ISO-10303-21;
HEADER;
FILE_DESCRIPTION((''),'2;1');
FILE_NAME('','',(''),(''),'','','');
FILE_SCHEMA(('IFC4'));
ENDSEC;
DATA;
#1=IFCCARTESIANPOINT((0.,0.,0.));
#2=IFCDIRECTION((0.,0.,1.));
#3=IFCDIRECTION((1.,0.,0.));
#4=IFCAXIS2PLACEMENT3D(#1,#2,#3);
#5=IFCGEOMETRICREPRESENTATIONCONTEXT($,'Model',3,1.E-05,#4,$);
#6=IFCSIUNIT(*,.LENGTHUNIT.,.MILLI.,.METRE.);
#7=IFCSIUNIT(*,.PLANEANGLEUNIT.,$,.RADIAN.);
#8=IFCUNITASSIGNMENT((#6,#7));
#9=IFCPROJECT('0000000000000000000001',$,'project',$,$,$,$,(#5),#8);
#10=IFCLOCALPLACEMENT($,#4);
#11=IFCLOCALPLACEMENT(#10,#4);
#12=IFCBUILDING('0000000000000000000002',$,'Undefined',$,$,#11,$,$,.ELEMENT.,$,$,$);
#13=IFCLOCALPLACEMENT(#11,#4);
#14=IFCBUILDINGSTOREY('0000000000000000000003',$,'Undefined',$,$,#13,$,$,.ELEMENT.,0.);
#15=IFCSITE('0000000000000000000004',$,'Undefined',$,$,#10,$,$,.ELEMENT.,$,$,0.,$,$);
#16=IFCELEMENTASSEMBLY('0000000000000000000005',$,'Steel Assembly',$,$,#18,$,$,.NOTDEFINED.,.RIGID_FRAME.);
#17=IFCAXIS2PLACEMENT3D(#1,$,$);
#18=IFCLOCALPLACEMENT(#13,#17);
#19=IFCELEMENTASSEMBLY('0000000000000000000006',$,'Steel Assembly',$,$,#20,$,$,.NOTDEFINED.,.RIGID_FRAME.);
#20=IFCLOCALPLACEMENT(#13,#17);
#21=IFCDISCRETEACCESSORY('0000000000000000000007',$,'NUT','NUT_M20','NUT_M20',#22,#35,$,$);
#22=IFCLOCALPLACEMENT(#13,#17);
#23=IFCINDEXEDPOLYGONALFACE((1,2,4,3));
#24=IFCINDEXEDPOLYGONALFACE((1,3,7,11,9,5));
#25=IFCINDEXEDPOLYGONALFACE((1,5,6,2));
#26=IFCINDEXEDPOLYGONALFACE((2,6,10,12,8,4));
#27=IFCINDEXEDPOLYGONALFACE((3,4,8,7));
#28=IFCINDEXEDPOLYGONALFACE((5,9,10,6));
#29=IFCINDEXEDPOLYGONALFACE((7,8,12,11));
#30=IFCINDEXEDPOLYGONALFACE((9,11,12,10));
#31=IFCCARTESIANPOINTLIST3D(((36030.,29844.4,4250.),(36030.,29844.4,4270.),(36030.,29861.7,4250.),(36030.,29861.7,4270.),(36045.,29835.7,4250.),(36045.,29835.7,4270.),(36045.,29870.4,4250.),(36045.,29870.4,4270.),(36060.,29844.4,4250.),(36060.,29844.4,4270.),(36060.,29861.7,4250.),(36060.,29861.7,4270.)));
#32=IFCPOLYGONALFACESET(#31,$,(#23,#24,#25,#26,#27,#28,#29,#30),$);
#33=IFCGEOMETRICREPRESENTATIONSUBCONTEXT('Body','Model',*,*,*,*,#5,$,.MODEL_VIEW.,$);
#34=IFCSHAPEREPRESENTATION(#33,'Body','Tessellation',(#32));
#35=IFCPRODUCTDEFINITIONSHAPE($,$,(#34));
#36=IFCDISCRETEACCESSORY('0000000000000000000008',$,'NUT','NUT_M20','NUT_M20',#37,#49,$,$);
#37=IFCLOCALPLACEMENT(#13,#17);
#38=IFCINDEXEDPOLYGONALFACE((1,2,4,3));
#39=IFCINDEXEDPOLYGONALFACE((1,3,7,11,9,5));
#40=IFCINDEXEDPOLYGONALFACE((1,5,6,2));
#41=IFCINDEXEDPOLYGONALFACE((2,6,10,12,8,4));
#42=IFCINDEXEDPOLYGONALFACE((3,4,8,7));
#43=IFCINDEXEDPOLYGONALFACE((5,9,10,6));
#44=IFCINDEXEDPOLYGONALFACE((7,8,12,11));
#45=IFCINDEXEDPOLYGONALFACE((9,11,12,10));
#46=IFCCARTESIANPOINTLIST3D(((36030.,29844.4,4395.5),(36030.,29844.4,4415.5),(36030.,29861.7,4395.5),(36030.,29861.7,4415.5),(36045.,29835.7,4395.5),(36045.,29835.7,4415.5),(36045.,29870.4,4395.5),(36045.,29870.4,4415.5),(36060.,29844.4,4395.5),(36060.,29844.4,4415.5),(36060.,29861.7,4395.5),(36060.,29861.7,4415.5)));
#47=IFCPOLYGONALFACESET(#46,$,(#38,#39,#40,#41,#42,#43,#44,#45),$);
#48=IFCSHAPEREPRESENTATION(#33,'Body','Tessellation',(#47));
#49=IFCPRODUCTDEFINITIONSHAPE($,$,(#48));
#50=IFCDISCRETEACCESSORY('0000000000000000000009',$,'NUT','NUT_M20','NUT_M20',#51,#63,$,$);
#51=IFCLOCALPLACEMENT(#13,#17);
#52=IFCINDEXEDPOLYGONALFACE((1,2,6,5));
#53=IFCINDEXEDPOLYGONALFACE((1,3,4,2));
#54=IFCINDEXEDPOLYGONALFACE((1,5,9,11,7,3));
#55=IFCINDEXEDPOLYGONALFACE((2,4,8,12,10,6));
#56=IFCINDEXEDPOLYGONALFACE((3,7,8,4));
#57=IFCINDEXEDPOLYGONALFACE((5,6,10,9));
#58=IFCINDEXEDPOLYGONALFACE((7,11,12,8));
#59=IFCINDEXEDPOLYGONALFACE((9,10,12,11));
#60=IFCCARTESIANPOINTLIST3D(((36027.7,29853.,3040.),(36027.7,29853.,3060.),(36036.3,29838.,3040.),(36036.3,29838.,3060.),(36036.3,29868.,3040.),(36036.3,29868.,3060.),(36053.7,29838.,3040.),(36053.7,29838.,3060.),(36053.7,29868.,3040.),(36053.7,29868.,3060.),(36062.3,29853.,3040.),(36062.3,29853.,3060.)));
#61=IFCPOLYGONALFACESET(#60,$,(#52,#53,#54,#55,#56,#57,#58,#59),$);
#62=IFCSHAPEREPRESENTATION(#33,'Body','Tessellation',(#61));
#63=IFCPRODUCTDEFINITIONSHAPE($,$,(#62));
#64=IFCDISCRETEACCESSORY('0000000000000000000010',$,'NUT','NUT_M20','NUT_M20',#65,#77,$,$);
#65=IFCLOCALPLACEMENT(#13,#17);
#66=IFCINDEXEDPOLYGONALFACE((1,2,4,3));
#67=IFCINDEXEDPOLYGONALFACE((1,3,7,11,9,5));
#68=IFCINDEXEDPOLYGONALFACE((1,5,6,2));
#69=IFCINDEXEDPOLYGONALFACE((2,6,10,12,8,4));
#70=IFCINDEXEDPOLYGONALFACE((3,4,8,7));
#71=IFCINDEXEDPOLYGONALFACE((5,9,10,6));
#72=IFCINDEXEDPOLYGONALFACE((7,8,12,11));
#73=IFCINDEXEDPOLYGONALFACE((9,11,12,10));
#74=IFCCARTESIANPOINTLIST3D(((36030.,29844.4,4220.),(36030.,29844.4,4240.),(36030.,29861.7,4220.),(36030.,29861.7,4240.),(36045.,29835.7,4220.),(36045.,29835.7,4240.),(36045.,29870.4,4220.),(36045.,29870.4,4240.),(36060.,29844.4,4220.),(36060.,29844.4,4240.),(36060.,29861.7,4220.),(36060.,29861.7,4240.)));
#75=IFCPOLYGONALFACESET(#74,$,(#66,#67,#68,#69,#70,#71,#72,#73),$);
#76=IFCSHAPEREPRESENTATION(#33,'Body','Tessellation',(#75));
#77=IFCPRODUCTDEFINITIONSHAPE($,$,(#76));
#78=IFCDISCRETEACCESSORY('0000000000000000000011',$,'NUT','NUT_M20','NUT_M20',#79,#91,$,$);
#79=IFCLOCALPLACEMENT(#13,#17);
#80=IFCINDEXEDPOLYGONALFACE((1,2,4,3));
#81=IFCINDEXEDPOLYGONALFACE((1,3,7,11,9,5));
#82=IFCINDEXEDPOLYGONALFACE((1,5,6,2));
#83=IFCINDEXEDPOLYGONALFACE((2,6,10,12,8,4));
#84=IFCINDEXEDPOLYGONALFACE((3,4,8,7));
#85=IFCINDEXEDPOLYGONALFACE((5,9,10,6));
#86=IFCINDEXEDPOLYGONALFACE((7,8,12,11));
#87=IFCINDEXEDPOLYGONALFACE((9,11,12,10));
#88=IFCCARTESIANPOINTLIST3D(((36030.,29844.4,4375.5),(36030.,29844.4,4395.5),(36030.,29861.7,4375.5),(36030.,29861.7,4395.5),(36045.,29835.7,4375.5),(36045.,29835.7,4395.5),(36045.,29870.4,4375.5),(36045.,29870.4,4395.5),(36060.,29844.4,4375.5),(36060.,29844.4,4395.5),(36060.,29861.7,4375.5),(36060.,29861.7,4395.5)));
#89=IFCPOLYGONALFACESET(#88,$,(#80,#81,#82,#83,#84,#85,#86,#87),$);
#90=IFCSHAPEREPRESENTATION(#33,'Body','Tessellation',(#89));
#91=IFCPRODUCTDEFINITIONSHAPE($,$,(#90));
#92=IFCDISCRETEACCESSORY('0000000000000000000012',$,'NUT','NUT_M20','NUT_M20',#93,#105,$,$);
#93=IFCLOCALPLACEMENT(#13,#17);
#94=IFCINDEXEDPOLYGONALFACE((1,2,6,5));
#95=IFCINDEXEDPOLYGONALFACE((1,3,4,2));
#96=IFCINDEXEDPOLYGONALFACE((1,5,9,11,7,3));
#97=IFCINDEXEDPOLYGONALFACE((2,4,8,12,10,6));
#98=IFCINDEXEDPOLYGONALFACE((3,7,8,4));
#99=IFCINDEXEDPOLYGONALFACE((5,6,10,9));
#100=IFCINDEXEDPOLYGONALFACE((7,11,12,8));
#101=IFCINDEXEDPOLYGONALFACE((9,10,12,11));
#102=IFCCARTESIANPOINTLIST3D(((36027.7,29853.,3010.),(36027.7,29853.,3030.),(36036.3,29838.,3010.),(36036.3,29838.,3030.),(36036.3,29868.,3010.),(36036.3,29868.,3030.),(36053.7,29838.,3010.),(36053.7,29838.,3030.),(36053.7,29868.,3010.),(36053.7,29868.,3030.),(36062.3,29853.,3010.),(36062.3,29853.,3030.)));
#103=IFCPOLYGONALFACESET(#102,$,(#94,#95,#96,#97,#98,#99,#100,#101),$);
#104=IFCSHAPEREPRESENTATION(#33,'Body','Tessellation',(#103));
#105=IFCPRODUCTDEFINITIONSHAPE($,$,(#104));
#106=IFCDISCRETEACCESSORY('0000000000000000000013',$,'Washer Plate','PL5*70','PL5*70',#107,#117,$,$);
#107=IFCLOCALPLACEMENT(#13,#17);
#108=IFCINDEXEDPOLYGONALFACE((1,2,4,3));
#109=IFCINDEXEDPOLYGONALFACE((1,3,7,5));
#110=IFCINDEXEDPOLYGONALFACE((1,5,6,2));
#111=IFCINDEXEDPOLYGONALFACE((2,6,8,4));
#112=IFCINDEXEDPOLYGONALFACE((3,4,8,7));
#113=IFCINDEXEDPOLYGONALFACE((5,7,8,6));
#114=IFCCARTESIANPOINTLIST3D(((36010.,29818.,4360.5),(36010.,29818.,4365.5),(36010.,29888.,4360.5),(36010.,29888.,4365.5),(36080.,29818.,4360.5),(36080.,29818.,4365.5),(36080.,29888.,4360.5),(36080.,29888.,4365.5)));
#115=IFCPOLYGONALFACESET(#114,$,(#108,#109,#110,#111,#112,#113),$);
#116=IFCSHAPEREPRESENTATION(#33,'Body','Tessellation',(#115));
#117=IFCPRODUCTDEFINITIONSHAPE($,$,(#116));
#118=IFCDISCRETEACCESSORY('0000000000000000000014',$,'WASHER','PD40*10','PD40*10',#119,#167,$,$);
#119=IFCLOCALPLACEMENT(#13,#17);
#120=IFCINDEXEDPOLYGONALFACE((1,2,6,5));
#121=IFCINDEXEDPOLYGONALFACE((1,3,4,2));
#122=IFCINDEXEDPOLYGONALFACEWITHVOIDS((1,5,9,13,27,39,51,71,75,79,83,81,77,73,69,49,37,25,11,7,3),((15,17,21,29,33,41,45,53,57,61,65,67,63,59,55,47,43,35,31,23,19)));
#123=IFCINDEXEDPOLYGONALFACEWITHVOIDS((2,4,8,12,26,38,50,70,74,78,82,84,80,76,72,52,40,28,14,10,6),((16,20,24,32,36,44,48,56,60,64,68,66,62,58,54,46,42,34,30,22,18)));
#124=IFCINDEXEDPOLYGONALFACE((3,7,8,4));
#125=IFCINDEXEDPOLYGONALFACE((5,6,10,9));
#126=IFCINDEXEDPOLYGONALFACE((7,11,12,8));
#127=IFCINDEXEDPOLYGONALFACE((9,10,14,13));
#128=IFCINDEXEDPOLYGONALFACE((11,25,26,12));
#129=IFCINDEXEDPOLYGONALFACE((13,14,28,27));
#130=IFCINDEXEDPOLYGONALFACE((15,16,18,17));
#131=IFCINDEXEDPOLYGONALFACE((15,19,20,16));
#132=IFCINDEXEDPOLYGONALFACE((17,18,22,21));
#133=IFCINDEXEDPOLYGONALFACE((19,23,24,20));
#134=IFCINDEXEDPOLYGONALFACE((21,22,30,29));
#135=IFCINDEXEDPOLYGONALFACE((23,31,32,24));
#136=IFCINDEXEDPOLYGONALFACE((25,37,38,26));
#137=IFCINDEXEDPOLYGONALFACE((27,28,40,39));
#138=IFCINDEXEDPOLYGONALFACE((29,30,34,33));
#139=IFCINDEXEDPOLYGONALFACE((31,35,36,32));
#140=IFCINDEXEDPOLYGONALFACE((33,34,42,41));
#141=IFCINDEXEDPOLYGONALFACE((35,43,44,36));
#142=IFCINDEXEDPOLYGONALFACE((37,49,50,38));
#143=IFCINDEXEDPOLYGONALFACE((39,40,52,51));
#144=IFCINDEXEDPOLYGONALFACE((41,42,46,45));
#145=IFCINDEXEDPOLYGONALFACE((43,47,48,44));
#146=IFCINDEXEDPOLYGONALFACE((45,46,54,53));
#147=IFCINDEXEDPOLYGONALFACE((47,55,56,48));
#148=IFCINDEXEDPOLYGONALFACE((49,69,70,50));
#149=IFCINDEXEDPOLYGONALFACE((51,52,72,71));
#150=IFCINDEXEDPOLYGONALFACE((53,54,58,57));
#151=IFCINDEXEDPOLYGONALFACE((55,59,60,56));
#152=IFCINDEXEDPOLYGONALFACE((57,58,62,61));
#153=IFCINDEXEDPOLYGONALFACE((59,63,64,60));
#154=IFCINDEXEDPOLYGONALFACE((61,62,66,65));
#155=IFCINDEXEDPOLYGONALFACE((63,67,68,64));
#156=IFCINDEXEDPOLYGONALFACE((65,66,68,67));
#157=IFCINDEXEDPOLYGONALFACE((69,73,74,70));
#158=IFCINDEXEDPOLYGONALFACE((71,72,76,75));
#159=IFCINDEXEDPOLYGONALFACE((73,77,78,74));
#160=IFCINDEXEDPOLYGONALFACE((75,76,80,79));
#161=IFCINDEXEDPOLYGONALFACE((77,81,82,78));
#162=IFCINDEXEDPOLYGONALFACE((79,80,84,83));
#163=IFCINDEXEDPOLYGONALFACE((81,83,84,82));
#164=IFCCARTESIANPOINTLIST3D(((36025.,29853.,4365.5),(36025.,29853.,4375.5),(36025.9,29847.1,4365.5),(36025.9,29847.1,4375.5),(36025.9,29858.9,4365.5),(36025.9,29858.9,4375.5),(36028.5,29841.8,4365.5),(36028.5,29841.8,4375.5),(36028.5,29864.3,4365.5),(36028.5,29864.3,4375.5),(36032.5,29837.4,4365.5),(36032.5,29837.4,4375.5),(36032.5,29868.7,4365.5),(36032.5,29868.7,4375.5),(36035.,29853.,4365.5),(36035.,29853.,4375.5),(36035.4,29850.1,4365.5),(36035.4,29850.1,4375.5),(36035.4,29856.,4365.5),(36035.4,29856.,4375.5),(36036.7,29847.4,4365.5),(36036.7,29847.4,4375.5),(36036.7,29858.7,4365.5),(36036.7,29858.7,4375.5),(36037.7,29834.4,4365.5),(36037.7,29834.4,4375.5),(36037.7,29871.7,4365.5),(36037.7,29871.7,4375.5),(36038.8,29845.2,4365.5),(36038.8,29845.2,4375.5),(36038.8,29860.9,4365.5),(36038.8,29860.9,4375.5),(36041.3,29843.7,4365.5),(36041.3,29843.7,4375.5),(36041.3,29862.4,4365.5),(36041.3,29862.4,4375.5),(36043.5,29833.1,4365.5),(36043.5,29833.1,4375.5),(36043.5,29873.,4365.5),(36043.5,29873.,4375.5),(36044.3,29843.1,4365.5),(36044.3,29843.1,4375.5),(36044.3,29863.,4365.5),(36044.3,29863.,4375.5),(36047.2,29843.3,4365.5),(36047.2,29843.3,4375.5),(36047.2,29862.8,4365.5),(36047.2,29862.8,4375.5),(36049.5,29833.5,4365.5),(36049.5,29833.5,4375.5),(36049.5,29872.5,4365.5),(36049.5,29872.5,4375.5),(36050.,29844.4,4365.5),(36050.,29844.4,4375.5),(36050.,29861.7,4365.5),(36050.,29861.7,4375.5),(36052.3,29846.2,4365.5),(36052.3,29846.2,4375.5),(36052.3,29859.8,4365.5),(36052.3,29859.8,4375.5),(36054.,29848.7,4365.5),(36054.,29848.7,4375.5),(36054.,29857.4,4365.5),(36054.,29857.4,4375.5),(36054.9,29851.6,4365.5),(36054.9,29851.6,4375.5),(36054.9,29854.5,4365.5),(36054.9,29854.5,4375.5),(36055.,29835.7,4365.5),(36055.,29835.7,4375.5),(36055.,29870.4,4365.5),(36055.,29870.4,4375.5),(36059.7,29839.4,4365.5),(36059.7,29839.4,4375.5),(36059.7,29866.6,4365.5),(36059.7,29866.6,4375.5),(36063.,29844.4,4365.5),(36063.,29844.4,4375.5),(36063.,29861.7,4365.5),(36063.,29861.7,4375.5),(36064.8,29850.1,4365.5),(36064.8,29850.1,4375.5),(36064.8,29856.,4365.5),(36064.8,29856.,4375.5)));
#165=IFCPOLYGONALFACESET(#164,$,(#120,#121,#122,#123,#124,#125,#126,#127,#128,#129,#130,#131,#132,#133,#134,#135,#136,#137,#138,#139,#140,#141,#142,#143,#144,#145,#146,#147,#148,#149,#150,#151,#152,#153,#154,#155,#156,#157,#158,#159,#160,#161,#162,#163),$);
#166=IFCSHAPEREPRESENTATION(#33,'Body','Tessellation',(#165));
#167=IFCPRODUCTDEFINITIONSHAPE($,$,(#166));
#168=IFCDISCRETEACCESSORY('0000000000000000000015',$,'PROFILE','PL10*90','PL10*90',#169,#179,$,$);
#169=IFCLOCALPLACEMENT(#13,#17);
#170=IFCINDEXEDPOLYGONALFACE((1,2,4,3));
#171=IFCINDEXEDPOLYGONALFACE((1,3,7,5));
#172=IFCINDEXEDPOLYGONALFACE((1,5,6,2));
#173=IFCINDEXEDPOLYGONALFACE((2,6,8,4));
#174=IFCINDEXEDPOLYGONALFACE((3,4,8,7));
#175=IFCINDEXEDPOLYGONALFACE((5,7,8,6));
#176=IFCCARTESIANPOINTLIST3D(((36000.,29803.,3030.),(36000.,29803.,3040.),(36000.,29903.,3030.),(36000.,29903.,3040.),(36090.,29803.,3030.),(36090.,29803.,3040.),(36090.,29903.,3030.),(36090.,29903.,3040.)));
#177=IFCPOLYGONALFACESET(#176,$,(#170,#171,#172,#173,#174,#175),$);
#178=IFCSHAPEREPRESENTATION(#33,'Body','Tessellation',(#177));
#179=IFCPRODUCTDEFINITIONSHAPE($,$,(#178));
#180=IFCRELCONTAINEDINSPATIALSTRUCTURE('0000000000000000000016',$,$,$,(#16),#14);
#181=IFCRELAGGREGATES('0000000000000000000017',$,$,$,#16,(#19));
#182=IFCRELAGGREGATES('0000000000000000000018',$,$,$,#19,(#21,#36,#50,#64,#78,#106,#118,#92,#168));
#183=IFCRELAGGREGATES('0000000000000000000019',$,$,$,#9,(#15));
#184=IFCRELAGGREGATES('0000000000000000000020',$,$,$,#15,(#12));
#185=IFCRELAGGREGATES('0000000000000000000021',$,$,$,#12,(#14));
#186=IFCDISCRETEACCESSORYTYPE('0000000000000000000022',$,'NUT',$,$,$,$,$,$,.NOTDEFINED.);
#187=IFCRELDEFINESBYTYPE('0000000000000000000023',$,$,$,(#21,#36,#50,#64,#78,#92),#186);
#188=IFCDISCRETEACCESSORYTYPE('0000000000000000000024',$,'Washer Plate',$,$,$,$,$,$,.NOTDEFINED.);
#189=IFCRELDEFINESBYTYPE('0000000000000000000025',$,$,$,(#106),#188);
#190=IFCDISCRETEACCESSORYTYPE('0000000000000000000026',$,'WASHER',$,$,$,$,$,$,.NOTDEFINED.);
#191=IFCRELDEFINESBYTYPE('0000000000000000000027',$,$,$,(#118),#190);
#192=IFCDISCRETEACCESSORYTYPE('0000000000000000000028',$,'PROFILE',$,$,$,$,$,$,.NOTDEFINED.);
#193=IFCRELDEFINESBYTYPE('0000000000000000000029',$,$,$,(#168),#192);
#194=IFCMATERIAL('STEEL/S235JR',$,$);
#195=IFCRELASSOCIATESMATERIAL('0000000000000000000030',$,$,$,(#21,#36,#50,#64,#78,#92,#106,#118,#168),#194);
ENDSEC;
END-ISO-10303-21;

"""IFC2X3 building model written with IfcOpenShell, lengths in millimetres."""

from ifc_helpers import new_model, si_unit, frame, origin_with_axes, origin_2d_with_axis, place, context, subcontext, project, spatial, polyline, hollow_circle, outline, extrude, material, type_object, element, aggregate, save


model = new_model("IFC2X3")

# Units and contexts
model_context = context("Model", 3, precision=1e-05, world=origin_with_axes())
body_context = subcontext(model_context, "Body", "Model", "MODEL_VIEW")
ifc_project = project(units=[si_unit("LENGTHUNIT", "METRE", prefix="MILLI"), si_unit("PLANEANGLEUNIT", "RADIAN")], contexts=[model_context])

# Site, building, storey
site_placement = place(None, origin_with_axes())
site = spatial("IfcSite", under=ifc_project, at=site_placement, Name="Undefined", CompositionType="ELEMENT", RefElevation=0.0)
building_placement = place(site_placement, origin_with_axes())
building = spatial("IfcBuilding", under=site, at=building_placement, Name="Undefined", CompositionType="ELEMENT")
storey_placement = place(building_placement, origin_with_axes())
storey = spatial("IfcBuildingStorey", under=building, at=storey_placement, Name="Undefined", CompositionType="ELEMENT", Elevation=0.0)

# Element assemblies
assembly_1_placement = place(storey_placement, origin_with_axes())
assembly_1 = element("IfcElementAssembly", 1, at=assembly_1_placement, inside=storey, Name="Steel Assembly", AssemblyPlace="NOTDEFINED", PredefinedType="RIGID_FRAME")
assembly_2_placement = place(assembly_1_placement, origin_with_axes())
assembly_2 = element("IfcElementAssembly", 2, at=assembly_2_placement, Name="Steel Assembly", AssemblyPlace="NOTDEFINED", PredefinedType="RIGID_FRAME")

# Shared definitions
ifc_material_1 = material(Name="STEEL/S235JR")

aggregate(assembly_1, [assembly_2])

# Discrete accessories
discrete_accessory_type_1 = type_object("IfcDiscreteAccessoryType", Name="NUT")
discrete_accessory_1_placement = place(assembly_2_placement, frame((36045.0, 29853.0, 4270.0), z_axis=(-1.0, 0.0, 0.0), x_axis=(0.0, 0.0, -1.0)))
discrete_accessory_1 = element("IfcDiscreteAccessory", 3, at=discrete_accessory_1_placement, type_object=discrete_accessory_type_1, material=ifc_material_1, Name="NUT", Description="NUT_M20", ObjectType="NUT_M20", context=body_context, shape_type="SweptSolid", body=[
    extrude(outline(polyline([(8.7, 15.0), (17.3, 0.0), (8.7, -15.0), (-8.7, -15.0), (-17.3, 0.0), (-8.7, 15.0), (8.7, 15.0)])), frame((20.0, 0.0, 0.0), z_axis=(-1.0, 0.0, 0.0), x_axis=(0.0, -1.0, 0.0)), (0.0, 0.0, 1.0), 20.0),
])
discrete_accessory_2_placement = place(assembly_2_placement, frame((36045.0, 29853.0, 4415.5), z_axis=(-1.0, 0.0, 0.0), x_axis=(0.0, 0.0, -1.0)))
discrete_accessory_2 = element("IfcDiscreteAccessory", 4, at=discrete_accessory_2_placement, type_object=discrete_accessory_type_1, material=ifc_material_1, Name="NUT", Description="NUT_M20", ObjectType="NUT_M20", context=body_context, shape_type="SweptSolid", body=[
    extrude(outline(polyline([(8.7, 15.0), (17.3, 0.0), (8.7, -15.0), (-8.7, -15.0), (-17.3, 0.0), (-8.7, 15.0), (8.7, 15.0)])), frame((20.0, 0.0, 0.0), z_axis=(-1.0, 0.0, 0.0), x_axis=(0.0, -1.0, 0.0)), (0.0, 0.0, 1.0), 20.0),
])
discrete_accessory_3_placement = place(assembly_2_placement, frame((36045.0, 29853.0, 3060.0), z_axis=(0.0, -1.0, 0.0), x_axis=(0.0, 0.0, -1.0)))
discrete_accessory_3 = element("IfcDiscreteAccessory", 5, at=discrete_accessory_3_placement, type_object=discrete_accessory_type_1, material=ifc_material_1, Name="NUT", Description="NUT_M20", ObjectType="NUT_M20", context=body_context, shape_type="SweptSolid", body=[
    extrude(outline(polyline([(8.7, 15.0), (17.3, 0.0), (8.7, -15.0), (-8.7, -15.0), (-17.3, 0.0), (-8.7, 15.0), (8.7, 15.0)])), frame((20.0, 0.0, 0.0), z_axis=(-1.0, 0.0, 0.0), x_axis=(0.0, -1.0, 0.0)), (0.0, 0.0, 1.0), 20.0),
])
discrete_accessory_4_placement = place(assembly_2_placement, frame((36045.0, 29853.0, 4240.0), z_axis=(-1.0, 0.0, 0.0), x_axis=(0.0, 0.0, -1.0)))
discrete_accessory_4 = element("IfcDiscreteAccessory", 6, at=discrete_accessory_4_placement, type_object=discrete_accessory_type_1, material=ifc_material_1, Name="NUT", Description="NUT_M20", ObjectType="NUT_M20", context=body_context, shape_type="SweptSolid", body=[
    extrude(outline(polyline([(8.7, 15.0), (17.3, 0.0), (8.7, -15.0), (-8.7, -15.0), (-17.3, 0.0), (-8.7, 15.0), (8.7, 15.0)])), frame((20.0, 0.0, 0.0), z_axis=(-1.0, 0.0, 0.0), x_axis=(0.0, -1.0, 0.0)), (0.0, 0.0, 1.0), 20.0),
])
discrete_accessory_5_placement = place(assembly_2_placement, frame((36045.0, 29853.0, 4395.5), z_axis=(-1.0, 0.0, 0.0), x_axis=(0.0, 0.0, -1.0)))
discrete_accessory_5 = element("IfcDiscreteAccessory", 7, at=discrete_accessory_5_placement, type_object=discrete_accessory_type_1, material=ifc_material_1, Name="NUT", Description="NUT_M20", ObjectType="NUT_M20", context=body_context, shape_type="SweptSolid", body=[
    extrude(outline(polyline([(8.7, 15.0), (17.3, 0.0), (8.7, -15.0), (-8.7, -15.0), (-17.3, 0.0), (-8.7, 15.0), (8.7, 15.0)])), frame((20.0, 0.0, 0.0), z_axis=(-1.0, 0.0, 0.0), x_axis=(0.0, -1.0, 0.0)), (0.0, 0.0, 1.0), 20.0),
])
discrete_accessory_6_placement = place(assembly_2_placement, frame((36045.0, 29853.0, 3030.0), z_axis=(0.0, -1.0, 0.0), x_axis=(0.0, 0.0, -1.0)))
discrete_accessory_6 = element("IfcDiscreteAccessory", 8, at=discrete_accessory_6_placement, type_object=discrete_accessory_type_1, material=ifc_material_1, Name="NUT", Description="NUT_M20", ObjectType="NUT_M20", context=body_context, shape_type="SweptSolid", body=[
    extrude(outline(polyline([(8.7, 15.0), (17.3, 0.0), (8.7, -15.0), (-8.7, -15.0), (-17.3, 0.0), (-8.7, 15.0), (8.7, 15.0)])), frame((20.0, 0.0, 0.0), z_axis=(-1.0, 0.0, 0.0), x_axis=(0.0, -1.0, 0.0)), (0.0, 0.0, 1.0), 20.0),
])
discrete_accessory_type_2 = type_object("IfcDiscreteAccessoryType", Name="Washer Plate")
discrete_accessory_7_placement = place(assembly_2_placement, frame((36080.0, 29818.0, 4363.0), z_axis=(0.0, 0.0, 1.0), x_axis=(0.0, 1.0, 0.0)))
discrete_accessory_7 = element("IfcDiscreteAccessory", 9, at=discrete_accessory_7_placement, type_object=discrete_accessory_type_2, material=ifc_material_1, Name="Washer Plate", Description="PL5*70", ObjectType="PL5*70", context=body_context, shape_type="SweptSolid", body=[
    extrude(outline(polyline([(0.0, 0.0), (70.0, 0.0), (70.0, 70.0), (0.0, 70.0), (0.0, 0.0)])), frame((0.0, 0.0, -2.5), z_axis=(0.0, 0.0, 1.0), x_axis=(1.0, 0.0, 0.0)), (0.0, 0.0, 1.0), 5.0),
])
discrete_accessory_type_3 = type_object("IfcDiscreteAccessoryType", Name="WASHER")
discrete_accessory_8_placement = place(assembly_2_placement, frame((36045.0, 29853.0, 4375.5), z_axis=(0.0, -1.0, 0.0), x_axis=(0.0, 0.0, -1.0)))
discrete_accessory_8 = element("IfcDiscreteAccessory", 10, at=discrete_accessory_8_placement, type_object=discrete_accessory_type_3, material=ifc_material_1, Name="WASHER", Description="PD40*10", ObjectType="PD40*10", context=body_context, shape_type="SweptSolid", body=[
    extrude(hollow_circle(Radius=20.0, WallThickness=10.0, at=origin_2d_with_axis()), frame((10.0, 0.0, 0.0), z_axis=(-1.0, 0.0, 0.0), x_axis=(0.0, -1.0, 0.0)), (0.0, 0.0, 1.0), 10.0),
])
discrete_accessory_type_4 = type_object("IfcDiscreteAccessoryType", Name="PROFILE")
discrete_accessory_9_placement = place(assembly_2_placement, frame((36045.0, 29903.0, 3035.0), z_axis=(0.0, 0.0, 1.0), x_axis=(0.0, -1.0, 0.0)))
discrete_accessory_9 = element("IfcDiscreteAccessory", 11, at=discrete_accessory_9_placement, type_object=discrete_accessory_type_4, material=ifc_material_1, Name="PROFILE", Description="PL10*90", ObjectType="PL10*90", context=body_context, shape_type="SweptSolid", body=[
    extrude(outline(polyline([(100.0, -45.0), (0.0, -45.0), (0.0, 45.0), (100.0, 45.0), (100.0, -45.0)])), frame((0.0, 0.0, -5.0), z_axis=(0.0, 0.0, 1.0), x_axis=(1.0, 0.0, 0.0)), (0.0, 0.0, 1.0), 10.0),
])
aggregate(assembly_2, [discrete_accessory_1, discrete_accessory_2, discrete_accessory_3, discrete_accessory_4, discrete_accessory_5, discrete_accessory_7, discrete_accessory_8, discrete_accessory_6, discrete_accessory_9])

save(model, "model.ifc")
